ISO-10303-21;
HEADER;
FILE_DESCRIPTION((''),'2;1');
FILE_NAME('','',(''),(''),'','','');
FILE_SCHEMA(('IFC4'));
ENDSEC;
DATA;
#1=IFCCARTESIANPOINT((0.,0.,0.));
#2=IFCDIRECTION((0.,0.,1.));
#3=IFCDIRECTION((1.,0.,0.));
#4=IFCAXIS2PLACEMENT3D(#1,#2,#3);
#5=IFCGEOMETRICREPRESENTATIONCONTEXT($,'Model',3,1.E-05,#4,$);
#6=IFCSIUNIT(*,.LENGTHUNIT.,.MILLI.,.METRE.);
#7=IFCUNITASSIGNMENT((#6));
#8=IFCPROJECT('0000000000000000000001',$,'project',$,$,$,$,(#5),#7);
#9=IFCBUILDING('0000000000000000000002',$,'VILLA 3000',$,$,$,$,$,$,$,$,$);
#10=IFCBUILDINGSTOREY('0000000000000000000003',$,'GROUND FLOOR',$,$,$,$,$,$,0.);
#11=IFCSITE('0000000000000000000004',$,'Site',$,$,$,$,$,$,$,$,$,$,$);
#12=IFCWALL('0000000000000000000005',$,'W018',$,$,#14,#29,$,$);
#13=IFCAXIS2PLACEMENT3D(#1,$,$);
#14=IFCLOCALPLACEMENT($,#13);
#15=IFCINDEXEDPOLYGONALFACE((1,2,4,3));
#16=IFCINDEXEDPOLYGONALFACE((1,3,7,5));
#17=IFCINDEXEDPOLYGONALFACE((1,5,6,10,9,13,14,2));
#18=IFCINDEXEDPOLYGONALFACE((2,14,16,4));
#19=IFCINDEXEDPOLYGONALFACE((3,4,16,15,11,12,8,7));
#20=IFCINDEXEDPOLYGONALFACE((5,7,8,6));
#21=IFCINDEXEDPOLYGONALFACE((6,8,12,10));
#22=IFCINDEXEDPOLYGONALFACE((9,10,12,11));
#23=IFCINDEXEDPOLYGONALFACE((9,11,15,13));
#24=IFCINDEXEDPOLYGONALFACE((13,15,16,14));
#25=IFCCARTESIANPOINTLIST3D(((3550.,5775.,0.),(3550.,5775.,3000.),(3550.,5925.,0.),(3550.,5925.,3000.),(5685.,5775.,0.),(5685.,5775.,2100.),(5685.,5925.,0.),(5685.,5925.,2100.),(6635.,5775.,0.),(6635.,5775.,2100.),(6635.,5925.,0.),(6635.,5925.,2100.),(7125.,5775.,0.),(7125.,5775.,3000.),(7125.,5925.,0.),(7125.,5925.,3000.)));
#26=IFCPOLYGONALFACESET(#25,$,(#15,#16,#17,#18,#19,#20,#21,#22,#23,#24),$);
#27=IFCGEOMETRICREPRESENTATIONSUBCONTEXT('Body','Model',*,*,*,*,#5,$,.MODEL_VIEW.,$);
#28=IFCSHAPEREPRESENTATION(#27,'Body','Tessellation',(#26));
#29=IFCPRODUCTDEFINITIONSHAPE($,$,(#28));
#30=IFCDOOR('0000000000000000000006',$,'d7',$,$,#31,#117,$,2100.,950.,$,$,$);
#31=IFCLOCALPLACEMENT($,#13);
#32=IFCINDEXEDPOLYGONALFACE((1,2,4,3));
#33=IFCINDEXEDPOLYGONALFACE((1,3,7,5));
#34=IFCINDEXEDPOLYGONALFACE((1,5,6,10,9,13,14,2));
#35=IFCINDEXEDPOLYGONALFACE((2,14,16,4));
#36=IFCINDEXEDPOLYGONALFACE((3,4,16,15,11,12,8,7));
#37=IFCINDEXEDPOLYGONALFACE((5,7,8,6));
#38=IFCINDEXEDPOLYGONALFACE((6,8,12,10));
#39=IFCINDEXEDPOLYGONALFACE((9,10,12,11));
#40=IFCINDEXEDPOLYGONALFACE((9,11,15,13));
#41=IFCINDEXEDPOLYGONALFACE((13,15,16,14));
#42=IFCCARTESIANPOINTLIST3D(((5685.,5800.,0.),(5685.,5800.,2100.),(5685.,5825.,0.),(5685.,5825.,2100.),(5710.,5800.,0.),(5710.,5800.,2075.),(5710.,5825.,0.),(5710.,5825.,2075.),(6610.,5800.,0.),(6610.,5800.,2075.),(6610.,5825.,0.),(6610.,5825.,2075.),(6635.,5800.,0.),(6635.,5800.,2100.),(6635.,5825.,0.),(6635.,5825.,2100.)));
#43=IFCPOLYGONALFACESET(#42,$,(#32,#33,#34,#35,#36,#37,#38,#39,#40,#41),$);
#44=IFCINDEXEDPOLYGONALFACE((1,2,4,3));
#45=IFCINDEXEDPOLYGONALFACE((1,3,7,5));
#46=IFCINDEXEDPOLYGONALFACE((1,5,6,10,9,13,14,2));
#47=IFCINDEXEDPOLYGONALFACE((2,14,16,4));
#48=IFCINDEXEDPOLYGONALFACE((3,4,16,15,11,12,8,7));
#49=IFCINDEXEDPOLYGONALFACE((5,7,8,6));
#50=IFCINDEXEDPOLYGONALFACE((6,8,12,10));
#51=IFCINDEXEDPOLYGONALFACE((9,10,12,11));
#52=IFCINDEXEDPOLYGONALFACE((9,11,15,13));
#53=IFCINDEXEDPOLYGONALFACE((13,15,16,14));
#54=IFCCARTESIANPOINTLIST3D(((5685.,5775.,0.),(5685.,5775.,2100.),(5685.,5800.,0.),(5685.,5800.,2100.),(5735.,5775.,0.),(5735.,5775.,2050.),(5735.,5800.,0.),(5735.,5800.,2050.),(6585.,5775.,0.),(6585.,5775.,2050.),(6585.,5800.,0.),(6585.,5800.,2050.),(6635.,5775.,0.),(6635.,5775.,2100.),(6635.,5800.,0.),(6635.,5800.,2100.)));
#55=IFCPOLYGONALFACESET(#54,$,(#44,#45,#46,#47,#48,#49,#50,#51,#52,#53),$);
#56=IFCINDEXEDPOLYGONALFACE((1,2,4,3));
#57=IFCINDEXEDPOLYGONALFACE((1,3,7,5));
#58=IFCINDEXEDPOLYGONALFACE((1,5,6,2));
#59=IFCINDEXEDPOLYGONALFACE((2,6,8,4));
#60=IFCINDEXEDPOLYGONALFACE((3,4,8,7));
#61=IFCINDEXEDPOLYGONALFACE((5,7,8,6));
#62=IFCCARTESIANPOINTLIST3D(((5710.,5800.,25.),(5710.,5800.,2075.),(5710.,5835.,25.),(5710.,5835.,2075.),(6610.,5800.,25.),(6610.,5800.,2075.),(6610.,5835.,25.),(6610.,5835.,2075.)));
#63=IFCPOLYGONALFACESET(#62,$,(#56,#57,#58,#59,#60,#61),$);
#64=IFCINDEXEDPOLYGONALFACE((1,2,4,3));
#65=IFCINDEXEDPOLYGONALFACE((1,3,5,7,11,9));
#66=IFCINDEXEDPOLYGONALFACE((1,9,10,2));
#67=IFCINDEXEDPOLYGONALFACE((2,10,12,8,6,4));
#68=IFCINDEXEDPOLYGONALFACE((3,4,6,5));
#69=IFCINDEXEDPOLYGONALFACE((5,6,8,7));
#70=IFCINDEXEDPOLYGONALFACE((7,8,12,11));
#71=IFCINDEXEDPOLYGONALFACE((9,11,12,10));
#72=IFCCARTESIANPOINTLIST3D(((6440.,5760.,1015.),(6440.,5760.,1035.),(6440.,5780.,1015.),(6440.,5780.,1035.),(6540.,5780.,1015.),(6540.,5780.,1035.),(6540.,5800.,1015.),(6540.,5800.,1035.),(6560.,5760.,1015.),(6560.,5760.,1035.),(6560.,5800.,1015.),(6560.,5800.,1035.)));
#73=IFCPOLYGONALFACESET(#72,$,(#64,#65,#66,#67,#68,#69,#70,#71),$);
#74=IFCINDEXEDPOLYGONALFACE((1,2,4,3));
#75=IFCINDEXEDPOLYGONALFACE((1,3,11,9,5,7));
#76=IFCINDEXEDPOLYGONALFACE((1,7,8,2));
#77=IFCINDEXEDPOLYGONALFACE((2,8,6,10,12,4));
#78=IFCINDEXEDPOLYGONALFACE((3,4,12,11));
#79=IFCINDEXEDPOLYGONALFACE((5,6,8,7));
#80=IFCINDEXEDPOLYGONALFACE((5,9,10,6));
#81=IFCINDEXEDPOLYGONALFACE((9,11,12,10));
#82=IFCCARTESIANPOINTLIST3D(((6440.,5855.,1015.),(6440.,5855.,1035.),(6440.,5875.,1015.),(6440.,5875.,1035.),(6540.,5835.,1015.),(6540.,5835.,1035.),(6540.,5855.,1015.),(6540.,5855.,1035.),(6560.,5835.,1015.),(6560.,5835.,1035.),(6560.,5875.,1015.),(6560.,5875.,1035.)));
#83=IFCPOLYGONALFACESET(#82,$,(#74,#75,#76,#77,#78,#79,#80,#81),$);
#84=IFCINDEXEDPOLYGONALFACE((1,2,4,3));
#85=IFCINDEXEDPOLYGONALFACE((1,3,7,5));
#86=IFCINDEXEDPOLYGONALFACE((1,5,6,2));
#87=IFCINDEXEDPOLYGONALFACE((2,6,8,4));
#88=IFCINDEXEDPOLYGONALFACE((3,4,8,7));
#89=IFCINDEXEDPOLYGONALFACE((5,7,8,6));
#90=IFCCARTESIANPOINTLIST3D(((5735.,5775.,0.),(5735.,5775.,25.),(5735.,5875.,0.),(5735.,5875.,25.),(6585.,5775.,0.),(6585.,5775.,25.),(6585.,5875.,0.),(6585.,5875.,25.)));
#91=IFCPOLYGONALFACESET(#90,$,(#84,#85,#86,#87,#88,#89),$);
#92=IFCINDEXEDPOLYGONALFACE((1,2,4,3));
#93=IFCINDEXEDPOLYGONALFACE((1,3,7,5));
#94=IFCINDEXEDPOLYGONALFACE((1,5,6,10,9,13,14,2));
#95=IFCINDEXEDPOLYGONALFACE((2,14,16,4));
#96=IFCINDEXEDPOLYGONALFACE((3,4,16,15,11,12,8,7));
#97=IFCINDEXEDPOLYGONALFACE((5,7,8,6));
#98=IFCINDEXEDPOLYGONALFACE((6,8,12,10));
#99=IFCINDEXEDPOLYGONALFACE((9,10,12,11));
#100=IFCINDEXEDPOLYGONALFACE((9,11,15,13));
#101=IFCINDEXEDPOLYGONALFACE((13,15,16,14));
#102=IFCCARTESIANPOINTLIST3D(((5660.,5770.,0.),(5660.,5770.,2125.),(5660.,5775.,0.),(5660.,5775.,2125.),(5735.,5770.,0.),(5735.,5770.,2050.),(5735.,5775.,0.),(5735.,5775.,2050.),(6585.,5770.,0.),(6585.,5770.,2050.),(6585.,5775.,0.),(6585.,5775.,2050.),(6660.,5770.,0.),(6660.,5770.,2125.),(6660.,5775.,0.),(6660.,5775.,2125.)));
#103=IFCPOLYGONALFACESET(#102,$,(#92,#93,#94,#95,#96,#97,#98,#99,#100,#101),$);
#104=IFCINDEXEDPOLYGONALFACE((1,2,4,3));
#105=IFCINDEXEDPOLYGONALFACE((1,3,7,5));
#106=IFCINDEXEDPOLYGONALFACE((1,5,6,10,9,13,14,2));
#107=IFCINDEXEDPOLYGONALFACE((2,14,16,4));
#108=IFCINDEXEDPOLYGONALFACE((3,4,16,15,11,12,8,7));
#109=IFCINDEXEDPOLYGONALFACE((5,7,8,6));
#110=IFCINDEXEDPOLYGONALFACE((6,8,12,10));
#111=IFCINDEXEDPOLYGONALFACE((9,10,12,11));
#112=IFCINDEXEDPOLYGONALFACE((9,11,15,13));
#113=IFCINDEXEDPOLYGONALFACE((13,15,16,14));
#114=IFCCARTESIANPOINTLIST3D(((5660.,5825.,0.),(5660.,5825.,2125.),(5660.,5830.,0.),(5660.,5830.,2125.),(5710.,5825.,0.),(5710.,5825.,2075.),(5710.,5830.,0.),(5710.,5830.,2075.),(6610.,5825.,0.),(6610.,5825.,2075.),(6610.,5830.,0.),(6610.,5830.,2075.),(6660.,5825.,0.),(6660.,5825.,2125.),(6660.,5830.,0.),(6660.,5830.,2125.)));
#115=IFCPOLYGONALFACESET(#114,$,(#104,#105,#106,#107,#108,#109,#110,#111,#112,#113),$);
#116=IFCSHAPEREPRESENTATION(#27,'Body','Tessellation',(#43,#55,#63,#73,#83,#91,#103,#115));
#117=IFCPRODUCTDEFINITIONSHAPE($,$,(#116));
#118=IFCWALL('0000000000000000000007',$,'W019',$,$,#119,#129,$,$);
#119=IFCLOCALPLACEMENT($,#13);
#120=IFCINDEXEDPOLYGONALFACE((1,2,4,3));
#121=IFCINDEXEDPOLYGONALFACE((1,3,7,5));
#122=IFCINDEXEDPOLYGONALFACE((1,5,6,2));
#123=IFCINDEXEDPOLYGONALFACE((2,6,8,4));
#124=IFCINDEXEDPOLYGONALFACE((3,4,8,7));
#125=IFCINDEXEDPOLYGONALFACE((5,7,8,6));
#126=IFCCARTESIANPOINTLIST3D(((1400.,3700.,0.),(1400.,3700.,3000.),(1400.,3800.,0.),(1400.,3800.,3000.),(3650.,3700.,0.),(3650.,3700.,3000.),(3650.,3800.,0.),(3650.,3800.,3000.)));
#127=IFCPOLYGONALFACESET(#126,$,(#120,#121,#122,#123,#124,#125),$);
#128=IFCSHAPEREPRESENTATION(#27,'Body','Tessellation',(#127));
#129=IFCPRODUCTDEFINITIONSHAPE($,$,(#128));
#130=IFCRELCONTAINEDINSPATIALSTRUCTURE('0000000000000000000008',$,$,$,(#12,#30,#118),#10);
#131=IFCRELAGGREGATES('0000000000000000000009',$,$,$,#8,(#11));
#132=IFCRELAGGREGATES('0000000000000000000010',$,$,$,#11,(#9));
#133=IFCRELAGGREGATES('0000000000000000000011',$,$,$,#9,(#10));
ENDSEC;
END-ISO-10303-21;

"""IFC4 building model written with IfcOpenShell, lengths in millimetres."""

from ifc_helpers import new_model, si_unit, frame, origin_with_axes, place, context, subcontext, project, spatial, line, indexed_curve, outline, extrude, element, fill, save


model = new_model("IFC4")

# Units and contexts
model_context = context("Model", 3, precision=1e-05, world=origin_with_axes())
body_context = subcontext(model_context, "Body", "Model", "MODEL_VIEW")
ifc_project = project(units=[si_unit("LENGTHUNIT", "METRE", prefix="MILLI")], contexts=[model_context])

# Site, building, storey
site = spatial("IfcSite", under=ifc_project, Name="Site")
building = spatial("IfcBuilding", under=site, Name="VILLA 3000")
storey = spatial("IfcBuildingStorey", under=building, Name="GROUND FLOOR", Elevation=0.0)

# Wall, opening, door
wall_1_placement = place(None, frame((3550.0, 5850.0, 0.0), z_axis=(0.0, 0.0, 1.0), x_axis=(1.0, 0.0, 0.0)))
wall_1 = element("IfcWall", 1, at=wall_1_placement, inside=storey, Name="W018", context=body_context, shape_type="SweptSolid", body=[
    extrude(outline(indexed_curve([(0.0, 0.0), (0.0, 150.0), (3575.0, 150.0), (3575.0, 0.0), (0.0, 0.0)], self_intersect=False)), frame((0.0, -75.0, 0.0), z_axis=(0.0, 0.0, 1.0), x_axis=(1.0, 0.0, 0.0)), (0.0, 0.0, 1.0), 3000.0),
])
opening_1_placement = place(wall_1_placement, frame((2135.0, 0.0, 0.0), z_axis=(0.0, 0.0, 1.0), x_axis=(1.0, 0.0, 0.0)))
opening_1 = element("IfcOpeningElement", 2, at=opening_1_placement, cuts=wall_1, context=body_context, shape_type="SweptSolid", body=[
    extrude(outline(indexed_curve([(0.0, 0.0), (0.0, 250.0), (950.0, 250.0), (950.0, 0.0), (0.0, 0.0)], self_intersect=False)), frame((0.0, -125.0, 0.0), z_axis=(0.0, 0.0, 1.0), x_axis=(1.0, 0.0, 0.0)), (0.0, 0.0, 1.0), 2100.0),
])
door_1_placement = place(None, frame((5685.0, 5775.0, 0.0), z_axis=(0.0, 0.0, 1.0), x_axis=(1.0, 0.0, 0.0)))
door_1 = element("IfcDoor", 3, at=door_1_placement, inside=storey, Name="d7", OverallHeight=2100.0, OverallWidth=950.0, context=body_context, shape_type="SweptSolid", body=[
    extrude(outline(indexed_curve([(0.0, 0.0), (0.0, 2100.0), (950.0, 2100.0), (950.0, 0.0), (925.0, 0.0), (925.0, 2075.0), (25.0, 2075.0), (25.0, 0.0)], segments=[line(1, 2, 3, 4, 5, 6, 7, 8, 1)])), frame((0.0, 25.0, 0.0), z_axis=(0.0, -1.0, 0.0), x_axis=(1.0, 0.0, 0.0)), (0.0, 0.0, -1.0), 25.0),
    extrude(outline(indexed_curve([(0.0, 0.0), (0.0, 2100.0), (950.0, 2100.0), (950.0, 0.0), (900.0, 0.0), (900.0, 2050.0), (50.0, 2050.0), (50.0, 0.0)], segments=[line(1, 2, 3, 4, 5, 6, 7, 8, 1)])), frame((0.0, 0.0, 0.0), z_axis=(0.0, -1.0, 0.0), x_axis=(1.0, 0.0, 0.0)), (0.0, 0.0, -1.0), 25.0),
    extrude(outline(indexed_curve([(0.0, 0.0), (900.0, 0.0), (900.0, 35.0), (0.0, 35.0)], segments=[line(1, 2, 3, 4, 1)])), frame((25.0, 25.0, 25.0), z_axis=(0.0, 0.0, 1.0), x_axis=(1.0, 0.0, 0.0)), (0.0, 0.0, 1.0), 2050.0),
    extrude(outline(indexed_curve([(0.0, 0.0), (0.0, -40.0), (-120.0, -40.0), (-120.0, -20.0), (-20.0, -20.0), (-20.0, 0.0)], segments=[line(1, 2, 3, 4, 5, 6, 1)])), frame((875.0, 25.0, 1015.0), z_axis=(0.0, 0.0, 1.0), x_axis=(1.0, 0.0, 0.0)), (0.0, 0.0, 1.0), 20.0),
    extrude(outline(indexed_curve([(0.0, 0.0), (0.0, 40.0), (-120.0, 40.0), (-120.0, 20.0), (-20.0, 20.0), (-20.0, 0.0)], segments=[line(1, 2, 3, 4, 5, 6, 1)])), frame((875.0, 60.0, 1015.0), z_axis=(0.0, 0.0, 1.0), x_axis=(1.0, 0.0, 0.0)), (0.0, 0.0, 1.0), 20.0),
    extrude(outline(indexed_curve([(0.0, 0.0), (850.0, 0.0), (850.0, 100.0), (0.0, 100.0)], segments=[line(1, 2, 3, 4, 1)])), frame((50.0, 0.0, 0.0), z_axis=(0.0, 0.0, 1.0), x_axis=(1.0, 0.0, 0.0)), (0.0, 0.0, 1.0), 25.0),
    extrude(outline(indexed_curve([(0.0, 0.0), (0.0, 2125.0), (1000.0, 2125.0), (1000.0, 0.0), (925.0, 0.0), (925.0, 2050.0), (75.0, 2050.0), (75.0, 0.0)], segments=[line(1, 2, 3, 4, 5, 6, 7, 8, 1)])), frame((-25.0, -5.0, 0.0), z_axis=(0.0, -1.0, 0.0), x_axis=(1.0, 0.0, 0.0)), (0.0, 0.0, -1.0), 5.0),
    extrude(outline(indexed_curve([(0.0, 0.0), (0.0, 2125.0), (1000.0, 2125.0), (1000.0, 0.0), (950.0, 0.0), (950.0, 2075.0), (50.0, 2075.0), (50.0, 0.0)], segments=[line(1, 2, 3, 4, 5, 6, 7, 8, 1)])), frame((-25.0, 50.0, 0.0), z_axis=(0.0, -1.0, 0.0), x_axis=(1.0, 0.0, 0.0)), (0.0, 0.0, -1.0), 5.0),
])
fill(opening_1, door_1)

# Wall
wall_2_placement = place(None, frame((1400.0, 3750.0, 0.0), z_axis=(0.0, 0.0, 1.0), x_axis=(1.0, 0.0, 0.0)))
element("IfcWall", 4, at=wall_2_placement, inside=storey, Name="W019", context=body_context, shape_type="SweptSolid", body=[
    extrude(outline(indexed_curve([(0.0, 0.0), (0.0, 100.0), (2250.0, 100.0), (2250.0, 0.0), (0.0, 0.0)], self_intersect=False)), frame((0.0, -50.0, 0.0), z_axis=(0.0, 0.0, 1.0), x_axis=(1.0, 0.0, 0.0)), (0.0, 0.0, 1.0), 3000.0),
])

save(model, "model.ifc")
